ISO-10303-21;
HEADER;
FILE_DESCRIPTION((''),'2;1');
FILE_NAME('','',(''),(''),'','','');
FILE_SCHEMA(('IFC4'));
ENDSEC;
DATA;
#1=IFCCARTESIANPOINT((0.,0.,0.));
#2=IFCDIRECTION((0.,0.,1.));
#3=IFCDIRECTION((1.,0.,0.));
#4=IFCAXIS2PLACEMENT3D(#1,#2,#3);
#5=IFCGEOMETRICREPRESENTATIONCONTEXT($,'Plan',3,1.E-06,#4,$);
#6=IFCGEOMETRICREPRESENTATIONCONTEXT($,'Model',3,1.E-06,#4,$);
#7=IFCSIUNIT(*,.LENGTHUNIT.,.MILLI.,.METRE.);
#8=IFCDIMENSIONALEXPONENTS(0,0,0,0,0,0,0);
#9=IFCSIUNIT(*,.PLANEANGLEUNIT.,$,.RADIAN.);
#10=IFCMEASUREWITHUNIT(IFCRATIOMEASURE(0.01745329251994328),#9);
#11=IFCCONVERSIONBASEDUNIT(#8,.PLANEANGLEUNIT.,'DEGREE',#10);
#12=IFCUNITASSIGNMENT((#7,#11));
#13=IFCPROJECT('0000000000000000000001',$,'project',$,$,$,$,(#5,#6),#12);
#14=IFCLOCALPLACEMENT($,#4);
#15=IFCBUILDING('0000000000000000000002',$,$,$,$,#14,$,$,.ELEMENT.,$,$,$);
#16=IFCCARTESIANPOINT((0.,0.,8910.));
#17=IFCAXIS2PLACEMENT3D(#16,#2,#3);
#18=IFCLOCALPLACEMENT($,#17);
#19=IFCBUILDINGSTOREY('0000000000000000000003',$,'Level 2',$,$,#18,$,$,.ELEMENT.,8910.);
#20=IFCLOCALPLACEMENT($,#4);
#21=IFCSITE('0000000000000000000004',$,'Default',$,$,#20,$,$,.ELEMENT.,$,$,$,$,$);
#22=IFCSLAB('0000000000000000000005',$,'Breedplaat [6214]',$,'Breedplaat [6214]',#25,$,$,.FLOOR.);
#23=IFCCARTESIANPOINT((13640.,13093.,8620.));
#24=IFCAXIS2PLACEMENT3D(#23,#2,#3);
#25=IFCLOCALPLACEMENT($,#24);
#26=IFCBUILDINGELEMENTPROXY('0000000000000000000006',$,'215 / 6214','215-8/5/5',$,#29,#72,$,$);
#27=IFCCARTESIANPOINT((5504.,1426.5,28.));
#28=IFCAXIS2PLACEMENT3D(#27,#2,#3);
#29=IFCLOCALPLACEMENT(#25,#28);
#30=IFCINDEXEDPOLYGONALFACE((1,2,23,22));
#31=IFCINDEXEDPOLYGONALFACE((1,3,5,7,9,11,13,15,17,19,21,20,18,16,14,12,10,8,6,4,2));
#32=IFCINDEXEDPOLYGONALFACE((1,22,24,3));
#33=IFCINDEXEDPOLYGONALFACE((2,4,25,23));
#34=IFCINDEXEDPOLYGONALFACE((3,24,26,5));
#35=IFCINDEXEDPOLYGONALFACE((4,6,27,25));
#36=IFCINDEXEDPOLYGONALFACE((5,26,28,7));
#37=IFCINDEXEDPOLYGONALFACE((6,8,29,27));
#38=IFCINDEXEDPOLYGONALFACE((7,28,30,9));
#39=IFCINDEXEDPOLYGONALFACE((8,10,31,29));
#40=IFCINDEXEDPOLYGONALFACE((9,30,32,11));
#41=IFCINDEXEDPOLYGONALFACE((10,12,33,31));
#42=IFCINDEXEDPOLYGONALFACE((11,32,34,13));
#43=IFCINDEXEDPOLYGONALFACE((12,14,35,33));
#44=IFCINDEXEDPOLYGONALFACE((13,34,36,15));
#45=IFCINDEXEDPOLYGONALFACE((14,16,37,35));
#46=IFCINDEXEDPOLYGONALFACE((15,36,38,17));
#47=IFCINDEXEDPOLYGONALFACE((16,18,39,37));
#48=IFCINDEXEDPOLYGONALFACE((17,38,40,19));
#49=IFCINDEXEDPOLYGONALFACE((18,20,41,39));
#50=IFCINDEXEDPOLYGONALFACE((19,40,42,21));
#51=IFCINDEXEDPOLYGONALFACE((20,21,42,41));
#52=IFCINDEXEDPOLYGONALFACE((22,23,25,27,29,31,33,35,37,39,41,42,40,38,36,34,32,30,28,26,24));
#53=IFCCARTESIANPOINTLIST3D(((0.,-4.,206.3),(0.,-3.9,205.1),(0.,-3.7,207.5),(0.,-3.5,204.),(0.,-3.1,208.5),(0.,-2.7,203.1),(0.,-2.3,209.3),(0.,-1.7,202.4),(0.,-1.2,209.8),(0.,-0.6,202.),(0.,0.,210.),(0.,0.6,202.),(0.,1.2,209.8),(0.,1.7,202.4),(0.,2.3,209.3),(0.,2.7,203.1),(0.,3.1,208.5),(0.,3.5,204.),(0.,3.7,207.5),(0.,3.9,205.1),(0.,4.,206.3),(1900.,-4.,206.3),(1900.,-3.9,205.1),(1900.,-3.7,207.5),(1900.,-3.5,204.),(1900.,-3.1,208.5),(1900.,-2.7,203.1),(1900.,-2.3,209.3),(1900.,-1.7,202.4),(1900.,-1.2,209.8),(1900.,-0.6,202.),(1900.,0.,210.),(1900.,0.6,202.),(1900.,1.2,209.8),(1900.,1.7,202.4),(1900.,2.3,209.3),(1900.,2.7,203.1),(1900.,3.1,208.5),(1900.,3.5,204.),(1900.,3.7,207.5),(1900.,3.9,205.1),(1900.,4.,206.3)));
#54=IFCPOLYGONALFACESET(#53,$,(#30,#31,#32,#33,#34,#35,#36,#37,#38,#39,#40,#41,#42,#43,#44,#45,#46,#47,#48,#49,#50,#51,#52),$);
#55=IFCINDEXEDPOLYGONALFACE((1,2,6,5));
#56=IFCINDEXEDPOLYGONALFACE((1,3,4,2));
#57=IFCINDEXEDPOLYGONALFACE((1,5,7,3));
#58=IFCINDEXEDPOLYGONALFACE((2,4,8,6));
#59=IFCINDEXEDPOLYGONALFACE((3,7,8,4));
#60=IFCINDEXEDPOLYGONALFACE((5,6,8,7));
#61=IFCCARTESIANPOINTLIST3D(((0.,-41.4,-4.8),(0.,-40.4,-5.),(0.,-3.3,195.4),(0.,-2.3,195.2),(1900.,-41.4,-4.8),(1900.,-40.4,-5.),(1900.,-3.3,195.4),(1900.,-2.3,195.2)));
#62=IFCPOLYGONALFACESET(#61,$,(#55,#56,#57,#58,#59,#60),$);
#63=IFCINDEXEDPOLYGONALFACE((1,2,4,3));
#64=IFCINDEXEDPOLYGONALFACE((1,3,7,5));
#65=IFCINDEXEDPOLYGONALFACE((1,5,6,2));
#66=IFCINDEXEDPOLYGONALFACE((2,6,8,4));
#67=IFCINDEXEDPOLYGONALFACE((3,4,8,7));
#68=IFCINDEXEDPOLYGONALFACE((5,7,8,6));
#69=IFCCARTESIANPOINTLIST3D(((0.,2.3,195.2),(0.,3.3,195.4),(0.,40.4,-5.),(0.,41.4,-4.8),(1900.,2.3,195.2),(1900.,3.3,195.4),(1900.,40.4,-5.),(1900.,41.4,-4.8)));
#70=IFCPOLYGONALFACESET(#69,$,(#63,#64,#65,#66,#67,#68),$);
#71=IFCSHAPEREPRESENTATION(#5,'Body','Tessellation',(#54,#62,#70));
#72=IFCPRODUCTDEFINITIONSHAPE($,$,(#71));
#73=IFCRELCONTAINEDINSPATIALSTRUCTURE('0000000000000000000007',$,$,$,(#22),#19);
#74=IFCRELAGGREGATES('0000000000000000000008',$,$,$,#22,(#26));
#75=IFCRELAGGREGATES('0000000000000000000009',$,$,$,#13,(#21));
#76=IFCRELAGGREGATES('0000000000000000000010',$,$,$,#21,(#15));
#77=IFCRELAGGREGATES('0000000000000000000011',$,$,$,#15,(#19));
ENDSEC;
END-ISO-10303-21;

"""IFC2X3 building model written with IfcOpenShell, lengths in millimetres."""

from ifc_helpers import new_model, entity, si_unit, converted_unit, frame, origin_with_axes, origin_2d_with_axis, place, context, project, spatial, rectangle, circle, extrude, element, aggregate, save


model = new_model("IFC2X3")

# Units and contexts
plan_context = context("Plan", 3, precision=1e-06, world=origin_with_axes())
model_context = context("Model", 3, precision=1e-06, world=origin_with_axes())
ifc_project = project(units=[si_unit("LENGTHUNIT", "METRE", prefix="MILLI"), converted_unit("PLANEANGLEUNIT", "DEGREE", entity("IfcRatioMeasure", 0.01745329251994328), si_unit("PLANEANGLEUNIT", "RADIAN"), dimensions=[0, 0, 0, 0, 0, 0, 0])], contexts=[plan_context, model_context])

# Site, building, storey
site_placement = place(None, origin_with_axes())
site = spatial("IfcSite", under=ifc_project, at=site_placement, Name="Default", CompositionType="ELEMENT")
building_placement = place(None, origin_with_axes())
building = spatial("IfcBuilding", under=site, at=building_placement, CompositionType="ELEMENT")
storey_placement = place(None, frame((0.0, 0.0, 8910.0), z_axis=(0.0, 0.0, 1.0), x_axis=(1.0, 0.0, 0.0)))
storey = spatial("IfcBuildingStorey", under=building, at=storey_placement, Name="Level 2", CompositionType="ELEMENT", Elevation=8910.0)

# Slab, building element proxy
slab_1_placement = place(None, frame((13640.0, 13093.0, 8620.0), z_axis=(0.0, 0.0, 1.0), x_axis=(1.0, 0.0, 0.0)))
slab_1 = element("IfcSlab", 1, at=slab_1_placement, inside=storey, Name="Breedplaat [6214]", ObjectType="Breedplaat [6214]", PredefinedType="FLOOR")
proxy_1_placement = place(slab_1_placement, frame((5504.0, 1426.5, 28.0), z_axis=(0.0, 0.0, 1.0), x_axis=(1.0, 0.0, 0.0)))
proxy_1 = element("IfcBuildingElementProxy", 2, at=proxy_1_placement, Name="215 / 6214", Description="215-8/5/5", context=plan_context, shape_type="SweptSolid", body=[
    extrude(circle(Radius=4.0, at=origin_2d_with_axis()), frame((0.0, 0.0, 206.0), z_axis=(1.0, 0.0, 0.0), x_axis=(0.0, 0.0, 1.0)), (0.0, 0.0, 1.0), 1900.0),
    extrude(rectangle(XDim=203.8, YDim=1.0, at=origin_2d_with_axis()), frame((0.0, -21.9, 95.2), z_axis=(1.0, 0.0, 0.0), x_axis=(0.0, 0.187112, 0.982339)), (0.0, 0.0, 1.0), 1900.0),
    extrude(rectangle(XDim=203.8, YDim=1.0, at=origin_2d_with_axis()), frame((0.0, 21.9, 95.2), z_axis=(1.0, 0.0, 0.0), x_axis=(0.0, -0.187112, 0.982339)), (0.0, 0.0, 1.0), 1900.0),
])
aggregate(slab_1, [proxy_1])

save(model, "model.ifc")
